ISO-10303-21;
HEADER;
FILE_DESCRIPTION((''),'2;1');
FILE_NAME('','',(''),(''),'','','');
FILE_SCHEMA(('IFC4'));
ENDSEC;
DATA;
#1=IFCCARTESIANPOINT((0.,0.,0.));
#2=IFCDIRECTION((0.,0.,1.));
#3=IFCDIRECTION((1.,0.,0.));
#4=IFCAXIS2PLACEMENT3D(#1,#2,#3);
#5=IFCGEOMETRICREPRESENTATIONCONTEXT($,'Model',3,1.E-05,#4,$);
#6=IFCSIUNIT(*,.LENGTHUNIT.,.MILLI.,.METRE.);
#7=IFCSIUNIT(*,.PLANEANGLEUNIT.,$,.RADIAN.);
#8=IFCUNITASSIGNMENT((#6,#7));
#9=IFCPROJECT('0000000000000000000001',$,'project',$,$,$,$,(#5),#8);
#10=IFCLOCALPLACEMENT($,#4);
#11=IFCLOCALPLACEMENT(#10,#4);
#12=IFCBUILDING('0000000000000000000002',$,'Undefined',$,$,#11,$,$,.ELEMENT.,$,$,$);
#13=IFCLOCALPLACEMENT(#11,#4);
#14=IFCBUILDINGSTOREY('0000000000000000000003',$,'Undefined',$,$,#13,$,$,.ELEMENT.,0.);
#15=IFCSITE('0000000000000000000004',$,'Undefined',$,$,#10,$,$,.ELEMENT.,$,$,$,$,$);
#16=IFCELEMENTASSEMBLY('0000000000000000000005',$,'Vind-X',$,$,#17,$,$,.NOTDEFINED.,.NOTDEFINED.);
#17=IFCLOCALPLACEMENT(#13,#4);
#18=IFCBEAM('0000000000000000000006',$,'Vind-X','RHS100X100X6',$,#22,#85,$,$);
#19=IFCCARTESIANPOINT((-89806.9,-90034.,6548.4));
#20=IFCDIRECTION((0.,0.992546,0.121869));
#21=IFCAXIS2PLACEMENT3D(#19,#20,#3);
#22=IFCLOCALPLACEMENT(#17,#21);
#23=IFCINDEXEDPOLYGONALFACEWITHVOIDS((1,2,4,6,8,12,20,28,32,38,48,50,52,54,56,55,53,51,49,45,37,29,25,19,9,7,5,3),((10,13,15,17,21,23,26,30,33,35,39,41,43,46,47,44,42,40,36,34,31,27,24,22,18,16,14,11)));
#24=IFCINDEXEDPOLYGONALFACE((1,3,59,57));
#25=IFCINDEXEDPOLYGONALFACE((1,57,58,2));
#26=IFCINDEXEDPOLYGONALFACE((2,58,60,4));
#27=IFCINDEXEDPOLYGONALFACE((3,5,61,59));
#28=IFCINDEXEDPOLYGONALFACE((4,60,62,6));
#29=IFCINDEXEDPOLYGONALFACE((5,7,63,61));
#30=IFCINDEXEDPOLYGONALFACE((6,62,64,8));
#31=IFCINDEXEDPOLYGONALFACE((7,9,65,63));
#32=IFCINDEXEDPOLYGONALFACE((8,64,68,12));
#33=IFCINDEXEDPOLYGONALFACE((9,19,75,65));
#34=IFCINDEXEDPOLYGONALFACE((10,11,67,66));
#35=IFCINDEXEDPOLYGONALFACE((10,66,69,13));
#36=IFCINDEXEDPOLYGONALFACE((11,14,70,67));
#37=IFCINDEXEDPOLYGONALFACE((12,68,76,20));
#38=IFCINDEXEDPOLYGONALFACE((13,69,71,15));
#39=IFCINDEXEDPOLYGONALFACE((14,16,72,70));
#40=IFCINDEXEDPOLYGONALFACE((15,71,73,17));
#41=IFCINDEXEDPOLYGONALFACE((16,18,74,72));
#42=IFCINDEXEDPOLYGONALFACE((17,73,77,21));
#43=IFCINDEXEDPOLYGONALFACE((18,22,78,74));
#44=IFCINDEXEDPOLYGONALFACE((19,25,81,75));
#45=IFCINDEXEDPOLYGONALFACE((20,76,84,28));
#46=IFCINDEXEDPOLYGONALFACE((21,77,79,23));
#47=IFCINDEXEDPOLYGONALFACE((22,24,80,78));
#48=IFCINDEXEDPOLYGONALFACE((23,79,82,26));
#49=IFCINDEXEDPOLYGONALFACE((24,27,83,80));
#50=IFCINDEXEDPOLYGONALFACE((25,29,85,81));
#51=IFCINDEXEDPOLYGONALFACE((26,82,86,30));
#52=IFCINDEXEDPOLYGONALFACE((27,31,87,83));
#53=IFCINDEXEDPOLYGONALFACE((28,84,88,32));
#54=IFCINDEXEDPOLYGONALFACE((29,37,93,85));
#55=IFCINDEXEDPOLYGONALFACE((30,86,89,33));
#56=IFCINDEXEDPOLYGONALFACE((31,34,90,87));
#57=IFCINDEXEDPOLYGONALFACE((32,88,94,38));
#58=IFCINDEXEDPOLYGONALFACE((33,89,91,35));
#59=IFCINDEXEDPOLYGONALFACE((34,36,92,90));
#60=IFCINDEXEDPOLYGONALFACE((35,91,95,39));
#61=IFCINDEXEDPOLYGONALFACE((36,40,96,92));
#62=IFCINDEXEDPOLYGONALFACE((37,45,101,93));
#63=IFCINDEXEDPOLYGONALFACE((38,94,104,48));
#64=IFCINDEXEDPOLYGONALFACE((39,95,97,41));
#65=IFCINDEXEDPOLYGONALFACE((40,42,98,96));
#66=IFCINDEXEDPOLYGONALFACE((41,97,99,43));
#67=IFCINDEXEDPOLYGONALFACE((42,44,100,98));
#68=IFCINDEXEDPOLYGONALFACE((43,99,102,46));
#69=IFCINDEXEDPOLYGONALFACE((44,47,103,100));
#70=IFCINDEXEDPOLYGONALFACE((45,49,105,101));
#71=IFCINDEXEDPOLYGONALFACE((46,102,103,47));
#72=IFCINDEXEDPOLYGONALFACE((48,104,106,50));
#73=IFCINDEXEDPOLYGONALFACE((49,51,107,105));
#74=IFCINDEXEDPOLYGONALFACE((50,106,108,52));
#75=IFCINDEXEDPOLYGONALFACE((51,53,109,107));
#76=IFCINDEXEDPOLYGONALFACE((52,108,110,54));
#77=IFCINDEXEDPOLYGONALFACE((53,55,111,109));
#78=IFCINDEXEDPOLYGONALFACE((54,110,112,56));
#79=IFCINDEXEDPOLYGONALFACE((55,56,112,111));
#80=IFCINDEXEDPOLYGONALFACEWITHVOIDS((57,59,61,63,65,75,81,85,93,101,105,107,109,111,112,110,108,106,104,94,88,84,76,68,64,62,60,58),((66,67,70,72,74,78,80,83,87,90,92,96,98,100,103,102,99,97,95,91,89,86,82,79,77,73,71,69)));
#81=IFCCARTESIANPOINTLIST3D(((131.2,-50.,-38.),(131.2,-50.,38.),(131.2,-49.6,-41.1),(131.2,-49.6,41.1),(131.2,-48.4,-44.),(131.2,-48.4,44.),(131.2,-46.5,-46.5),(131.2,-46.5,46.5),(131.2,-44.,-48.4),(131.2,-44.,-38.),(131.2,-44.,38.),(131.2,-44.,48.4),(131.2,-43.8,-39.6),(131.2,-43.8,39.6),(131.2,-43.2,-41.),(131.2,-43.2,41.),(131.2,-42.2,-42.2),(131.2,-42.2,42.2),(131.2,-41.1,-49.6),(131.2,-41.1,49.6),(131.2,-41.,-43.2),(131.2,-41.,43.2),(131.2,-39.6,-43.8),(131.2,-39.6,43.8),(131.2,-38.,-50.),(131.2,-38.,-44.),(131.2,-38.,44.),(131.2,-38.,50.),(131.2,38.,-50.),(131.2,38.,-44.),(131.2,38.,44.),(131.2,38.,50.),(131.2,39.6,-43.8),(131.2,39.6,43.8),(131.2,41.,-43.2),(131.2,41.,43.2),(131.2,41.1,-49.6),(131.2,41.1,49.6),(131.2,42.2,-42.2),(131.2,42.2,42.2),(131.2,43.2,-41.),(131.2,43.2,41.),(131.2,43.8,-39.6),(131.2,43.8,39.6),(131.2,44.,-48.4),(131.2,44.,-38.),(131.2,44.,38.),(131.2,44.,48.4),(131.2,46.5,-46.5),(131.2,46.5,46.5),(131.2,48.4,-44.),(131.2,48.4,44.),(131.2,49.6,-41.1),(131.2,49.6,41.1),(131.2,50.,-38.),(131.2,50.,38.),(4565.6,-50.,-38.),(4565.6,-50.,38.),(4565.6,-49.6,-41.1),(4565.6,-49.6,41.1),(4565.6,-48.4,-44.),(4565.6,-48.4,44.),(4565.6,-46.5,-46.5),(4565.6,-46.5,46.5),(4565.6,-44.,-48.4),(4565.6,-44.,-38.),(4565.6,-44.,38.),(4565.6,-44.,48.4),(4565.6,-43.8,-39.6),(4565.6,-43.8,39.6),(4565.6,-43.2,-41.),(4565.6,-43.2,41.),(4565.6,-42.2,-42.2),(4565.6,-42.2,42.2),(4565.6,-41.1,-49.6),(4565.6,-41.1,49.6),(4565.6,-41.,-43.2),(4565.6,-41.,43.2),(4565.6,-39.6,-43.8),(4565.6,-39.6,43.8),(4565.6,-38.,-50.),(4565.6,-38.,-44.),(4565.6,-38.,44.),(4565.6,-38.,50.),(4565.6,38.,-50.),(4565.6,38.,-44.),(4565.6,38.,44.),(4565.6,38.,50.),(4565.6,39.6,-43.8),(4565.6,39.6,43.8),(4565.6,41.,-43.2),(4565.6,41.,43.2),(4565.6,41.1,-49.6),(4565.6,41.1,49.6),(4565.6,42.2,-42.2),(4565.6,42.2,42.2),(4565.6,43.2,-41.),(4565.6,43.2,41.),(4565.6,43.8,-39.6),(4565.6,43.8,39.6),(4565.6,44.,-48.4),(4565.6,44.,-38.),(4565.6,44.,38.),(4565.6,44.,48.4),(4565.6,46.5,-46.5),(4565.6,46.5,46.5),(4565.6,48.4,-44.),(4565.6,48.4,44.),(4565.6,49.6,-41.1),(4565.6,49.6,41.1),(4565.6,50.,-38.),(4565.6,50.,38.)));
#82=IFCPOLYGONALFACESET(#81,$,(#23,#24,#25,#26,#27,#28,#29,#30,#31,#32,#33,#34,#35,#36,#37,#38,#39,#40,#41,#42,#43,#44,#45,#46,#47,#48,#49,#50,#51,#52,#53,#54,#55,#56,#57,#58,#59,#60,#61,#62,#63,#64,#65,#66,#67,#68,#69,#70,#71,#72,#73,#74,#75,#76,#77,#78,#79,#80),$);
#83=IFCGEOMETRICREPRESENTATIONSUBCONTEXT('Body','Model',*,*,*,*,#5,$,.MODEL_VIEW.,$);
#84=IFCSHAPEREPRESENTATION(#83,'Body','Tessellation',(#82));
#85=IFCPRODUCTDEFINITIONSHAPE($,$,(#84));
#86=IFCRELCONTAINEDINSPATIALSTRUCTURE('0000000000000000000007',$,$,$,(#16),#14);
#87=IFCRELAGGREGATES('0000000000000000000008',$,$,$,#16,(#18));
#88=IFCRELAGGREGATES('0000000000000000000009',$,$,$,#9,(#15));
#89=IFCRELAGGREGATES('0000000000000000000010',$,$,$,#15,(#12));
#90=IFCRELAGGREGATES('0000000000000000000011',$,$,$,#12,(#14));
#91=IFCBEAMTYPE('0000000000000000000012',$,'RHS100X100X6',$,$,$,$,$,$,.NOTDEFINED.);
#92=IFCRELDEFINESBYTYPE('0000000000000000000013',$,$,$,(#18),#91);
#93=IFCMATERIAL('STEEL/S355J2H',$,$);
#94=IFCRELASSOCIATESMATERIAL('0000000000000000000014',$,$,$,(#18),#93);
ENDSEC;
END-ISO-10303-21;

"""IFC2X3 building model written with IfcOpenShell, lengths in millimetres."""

from ifc_helpers import new_model, si_unit, frame, origin_with_axes, origin_2d_with_axis, place, context, subcontext, project, spatial, hollow_rectangle, extrude, clip, halfspace, material, type_object, element, aggregate, save


model = new_model("IFC2X3")

# Units and contexts
model_context = context("Model", 3, precision=1e-05, world=origin_with_axes())
body_context = subcontext(model_context, "Body", "Model", "MODEL_VIEW")
ifc_project = project(units=[si_unit("LENGTHUNIT", "METRE", prefix="MILLI"), si_unit("PLANEANGLEUNIT", "RADIAN")], contexts=[model_context])

# Site, building, storey
site_placement = place(None, origin_with_axes())
site = spatial("IfcSite", under=ifc_project, at=site_placement, Name="Undefined", CompositionType="ELEMENT")
building_placement = place(site_placement, origin_with_axes())
building = spatial("IfcBuilding", under=site, at=building_placement, Name="Undefined", CompositionType="ELEMENT")
storey_placement = place(building_placement, origin_with_axes())
storey = spatial("IfcBuildingStorey", under=building, at=storey_placement, Name="Undefined", CompositionType="ELEMENT", Elevation=0.0)

# Element assembly, beam
assembly_1_placement = place(storey_placement, origin_with_axes())
assembly_1 = element("IfcElementAssembly", 1, at=assembly_1_placement, inside=storey, Name="Vind-X", AssemblyPlace="NOTDEFINED", PredefinedType="NOTDEFINED")
ifc_material_1 = material(Name="STEEL/S355J2H")
beam_type_1 = type_object("IfcBeamType", Name="RHS100X100X6", PredefinedType="NOTDEFINED")
beam_1_placement = place(assembly_1_placement, frame((-89806.9, -90034.0, 6548.4), z_axis=(0.0, 0.992546, 0.121869), x_axis=(1.0, 0.0, 0.0)))
beam_1 = element("IfcBeam", 2, at=beam_1_placement, type_object=beam_type_1, material=ifc_material_1, Name="Vind-X", Description="RHS100X100X6", context=body_context, shape_type="Clipping", body=[
    clip(clip(extrude(hollow_rectangle(XDim=100.0, YDim=100.0, WallThickness=6.0, InnerFilletRadius=6.0, OuterFilletRadius=12.0, at=origin_2d_with_axis()), frame((4644.6, 0.0, 0.0), z_axis=(-1.0, 0.0, 0.0), x_axis=(0.0, -1.0, 0.0)), (0.0, 0.0, 1.0), 4644.6), halfspace(frame((4565.6, 22.5, 0.0), z_axis=(-1.0, 0.0, 0.0), x_axis=(0.0, 0.0, 1.0)), True)), halfspace(frame((131.2, 22.5, 0.0), z_axis=(1.0, 0.0, 0.0), x_axis=(0.0, 0.0, -1.0)), True)),
])
aggregate(assembly_1, [beam_1])

save(model, "model.ifc")
